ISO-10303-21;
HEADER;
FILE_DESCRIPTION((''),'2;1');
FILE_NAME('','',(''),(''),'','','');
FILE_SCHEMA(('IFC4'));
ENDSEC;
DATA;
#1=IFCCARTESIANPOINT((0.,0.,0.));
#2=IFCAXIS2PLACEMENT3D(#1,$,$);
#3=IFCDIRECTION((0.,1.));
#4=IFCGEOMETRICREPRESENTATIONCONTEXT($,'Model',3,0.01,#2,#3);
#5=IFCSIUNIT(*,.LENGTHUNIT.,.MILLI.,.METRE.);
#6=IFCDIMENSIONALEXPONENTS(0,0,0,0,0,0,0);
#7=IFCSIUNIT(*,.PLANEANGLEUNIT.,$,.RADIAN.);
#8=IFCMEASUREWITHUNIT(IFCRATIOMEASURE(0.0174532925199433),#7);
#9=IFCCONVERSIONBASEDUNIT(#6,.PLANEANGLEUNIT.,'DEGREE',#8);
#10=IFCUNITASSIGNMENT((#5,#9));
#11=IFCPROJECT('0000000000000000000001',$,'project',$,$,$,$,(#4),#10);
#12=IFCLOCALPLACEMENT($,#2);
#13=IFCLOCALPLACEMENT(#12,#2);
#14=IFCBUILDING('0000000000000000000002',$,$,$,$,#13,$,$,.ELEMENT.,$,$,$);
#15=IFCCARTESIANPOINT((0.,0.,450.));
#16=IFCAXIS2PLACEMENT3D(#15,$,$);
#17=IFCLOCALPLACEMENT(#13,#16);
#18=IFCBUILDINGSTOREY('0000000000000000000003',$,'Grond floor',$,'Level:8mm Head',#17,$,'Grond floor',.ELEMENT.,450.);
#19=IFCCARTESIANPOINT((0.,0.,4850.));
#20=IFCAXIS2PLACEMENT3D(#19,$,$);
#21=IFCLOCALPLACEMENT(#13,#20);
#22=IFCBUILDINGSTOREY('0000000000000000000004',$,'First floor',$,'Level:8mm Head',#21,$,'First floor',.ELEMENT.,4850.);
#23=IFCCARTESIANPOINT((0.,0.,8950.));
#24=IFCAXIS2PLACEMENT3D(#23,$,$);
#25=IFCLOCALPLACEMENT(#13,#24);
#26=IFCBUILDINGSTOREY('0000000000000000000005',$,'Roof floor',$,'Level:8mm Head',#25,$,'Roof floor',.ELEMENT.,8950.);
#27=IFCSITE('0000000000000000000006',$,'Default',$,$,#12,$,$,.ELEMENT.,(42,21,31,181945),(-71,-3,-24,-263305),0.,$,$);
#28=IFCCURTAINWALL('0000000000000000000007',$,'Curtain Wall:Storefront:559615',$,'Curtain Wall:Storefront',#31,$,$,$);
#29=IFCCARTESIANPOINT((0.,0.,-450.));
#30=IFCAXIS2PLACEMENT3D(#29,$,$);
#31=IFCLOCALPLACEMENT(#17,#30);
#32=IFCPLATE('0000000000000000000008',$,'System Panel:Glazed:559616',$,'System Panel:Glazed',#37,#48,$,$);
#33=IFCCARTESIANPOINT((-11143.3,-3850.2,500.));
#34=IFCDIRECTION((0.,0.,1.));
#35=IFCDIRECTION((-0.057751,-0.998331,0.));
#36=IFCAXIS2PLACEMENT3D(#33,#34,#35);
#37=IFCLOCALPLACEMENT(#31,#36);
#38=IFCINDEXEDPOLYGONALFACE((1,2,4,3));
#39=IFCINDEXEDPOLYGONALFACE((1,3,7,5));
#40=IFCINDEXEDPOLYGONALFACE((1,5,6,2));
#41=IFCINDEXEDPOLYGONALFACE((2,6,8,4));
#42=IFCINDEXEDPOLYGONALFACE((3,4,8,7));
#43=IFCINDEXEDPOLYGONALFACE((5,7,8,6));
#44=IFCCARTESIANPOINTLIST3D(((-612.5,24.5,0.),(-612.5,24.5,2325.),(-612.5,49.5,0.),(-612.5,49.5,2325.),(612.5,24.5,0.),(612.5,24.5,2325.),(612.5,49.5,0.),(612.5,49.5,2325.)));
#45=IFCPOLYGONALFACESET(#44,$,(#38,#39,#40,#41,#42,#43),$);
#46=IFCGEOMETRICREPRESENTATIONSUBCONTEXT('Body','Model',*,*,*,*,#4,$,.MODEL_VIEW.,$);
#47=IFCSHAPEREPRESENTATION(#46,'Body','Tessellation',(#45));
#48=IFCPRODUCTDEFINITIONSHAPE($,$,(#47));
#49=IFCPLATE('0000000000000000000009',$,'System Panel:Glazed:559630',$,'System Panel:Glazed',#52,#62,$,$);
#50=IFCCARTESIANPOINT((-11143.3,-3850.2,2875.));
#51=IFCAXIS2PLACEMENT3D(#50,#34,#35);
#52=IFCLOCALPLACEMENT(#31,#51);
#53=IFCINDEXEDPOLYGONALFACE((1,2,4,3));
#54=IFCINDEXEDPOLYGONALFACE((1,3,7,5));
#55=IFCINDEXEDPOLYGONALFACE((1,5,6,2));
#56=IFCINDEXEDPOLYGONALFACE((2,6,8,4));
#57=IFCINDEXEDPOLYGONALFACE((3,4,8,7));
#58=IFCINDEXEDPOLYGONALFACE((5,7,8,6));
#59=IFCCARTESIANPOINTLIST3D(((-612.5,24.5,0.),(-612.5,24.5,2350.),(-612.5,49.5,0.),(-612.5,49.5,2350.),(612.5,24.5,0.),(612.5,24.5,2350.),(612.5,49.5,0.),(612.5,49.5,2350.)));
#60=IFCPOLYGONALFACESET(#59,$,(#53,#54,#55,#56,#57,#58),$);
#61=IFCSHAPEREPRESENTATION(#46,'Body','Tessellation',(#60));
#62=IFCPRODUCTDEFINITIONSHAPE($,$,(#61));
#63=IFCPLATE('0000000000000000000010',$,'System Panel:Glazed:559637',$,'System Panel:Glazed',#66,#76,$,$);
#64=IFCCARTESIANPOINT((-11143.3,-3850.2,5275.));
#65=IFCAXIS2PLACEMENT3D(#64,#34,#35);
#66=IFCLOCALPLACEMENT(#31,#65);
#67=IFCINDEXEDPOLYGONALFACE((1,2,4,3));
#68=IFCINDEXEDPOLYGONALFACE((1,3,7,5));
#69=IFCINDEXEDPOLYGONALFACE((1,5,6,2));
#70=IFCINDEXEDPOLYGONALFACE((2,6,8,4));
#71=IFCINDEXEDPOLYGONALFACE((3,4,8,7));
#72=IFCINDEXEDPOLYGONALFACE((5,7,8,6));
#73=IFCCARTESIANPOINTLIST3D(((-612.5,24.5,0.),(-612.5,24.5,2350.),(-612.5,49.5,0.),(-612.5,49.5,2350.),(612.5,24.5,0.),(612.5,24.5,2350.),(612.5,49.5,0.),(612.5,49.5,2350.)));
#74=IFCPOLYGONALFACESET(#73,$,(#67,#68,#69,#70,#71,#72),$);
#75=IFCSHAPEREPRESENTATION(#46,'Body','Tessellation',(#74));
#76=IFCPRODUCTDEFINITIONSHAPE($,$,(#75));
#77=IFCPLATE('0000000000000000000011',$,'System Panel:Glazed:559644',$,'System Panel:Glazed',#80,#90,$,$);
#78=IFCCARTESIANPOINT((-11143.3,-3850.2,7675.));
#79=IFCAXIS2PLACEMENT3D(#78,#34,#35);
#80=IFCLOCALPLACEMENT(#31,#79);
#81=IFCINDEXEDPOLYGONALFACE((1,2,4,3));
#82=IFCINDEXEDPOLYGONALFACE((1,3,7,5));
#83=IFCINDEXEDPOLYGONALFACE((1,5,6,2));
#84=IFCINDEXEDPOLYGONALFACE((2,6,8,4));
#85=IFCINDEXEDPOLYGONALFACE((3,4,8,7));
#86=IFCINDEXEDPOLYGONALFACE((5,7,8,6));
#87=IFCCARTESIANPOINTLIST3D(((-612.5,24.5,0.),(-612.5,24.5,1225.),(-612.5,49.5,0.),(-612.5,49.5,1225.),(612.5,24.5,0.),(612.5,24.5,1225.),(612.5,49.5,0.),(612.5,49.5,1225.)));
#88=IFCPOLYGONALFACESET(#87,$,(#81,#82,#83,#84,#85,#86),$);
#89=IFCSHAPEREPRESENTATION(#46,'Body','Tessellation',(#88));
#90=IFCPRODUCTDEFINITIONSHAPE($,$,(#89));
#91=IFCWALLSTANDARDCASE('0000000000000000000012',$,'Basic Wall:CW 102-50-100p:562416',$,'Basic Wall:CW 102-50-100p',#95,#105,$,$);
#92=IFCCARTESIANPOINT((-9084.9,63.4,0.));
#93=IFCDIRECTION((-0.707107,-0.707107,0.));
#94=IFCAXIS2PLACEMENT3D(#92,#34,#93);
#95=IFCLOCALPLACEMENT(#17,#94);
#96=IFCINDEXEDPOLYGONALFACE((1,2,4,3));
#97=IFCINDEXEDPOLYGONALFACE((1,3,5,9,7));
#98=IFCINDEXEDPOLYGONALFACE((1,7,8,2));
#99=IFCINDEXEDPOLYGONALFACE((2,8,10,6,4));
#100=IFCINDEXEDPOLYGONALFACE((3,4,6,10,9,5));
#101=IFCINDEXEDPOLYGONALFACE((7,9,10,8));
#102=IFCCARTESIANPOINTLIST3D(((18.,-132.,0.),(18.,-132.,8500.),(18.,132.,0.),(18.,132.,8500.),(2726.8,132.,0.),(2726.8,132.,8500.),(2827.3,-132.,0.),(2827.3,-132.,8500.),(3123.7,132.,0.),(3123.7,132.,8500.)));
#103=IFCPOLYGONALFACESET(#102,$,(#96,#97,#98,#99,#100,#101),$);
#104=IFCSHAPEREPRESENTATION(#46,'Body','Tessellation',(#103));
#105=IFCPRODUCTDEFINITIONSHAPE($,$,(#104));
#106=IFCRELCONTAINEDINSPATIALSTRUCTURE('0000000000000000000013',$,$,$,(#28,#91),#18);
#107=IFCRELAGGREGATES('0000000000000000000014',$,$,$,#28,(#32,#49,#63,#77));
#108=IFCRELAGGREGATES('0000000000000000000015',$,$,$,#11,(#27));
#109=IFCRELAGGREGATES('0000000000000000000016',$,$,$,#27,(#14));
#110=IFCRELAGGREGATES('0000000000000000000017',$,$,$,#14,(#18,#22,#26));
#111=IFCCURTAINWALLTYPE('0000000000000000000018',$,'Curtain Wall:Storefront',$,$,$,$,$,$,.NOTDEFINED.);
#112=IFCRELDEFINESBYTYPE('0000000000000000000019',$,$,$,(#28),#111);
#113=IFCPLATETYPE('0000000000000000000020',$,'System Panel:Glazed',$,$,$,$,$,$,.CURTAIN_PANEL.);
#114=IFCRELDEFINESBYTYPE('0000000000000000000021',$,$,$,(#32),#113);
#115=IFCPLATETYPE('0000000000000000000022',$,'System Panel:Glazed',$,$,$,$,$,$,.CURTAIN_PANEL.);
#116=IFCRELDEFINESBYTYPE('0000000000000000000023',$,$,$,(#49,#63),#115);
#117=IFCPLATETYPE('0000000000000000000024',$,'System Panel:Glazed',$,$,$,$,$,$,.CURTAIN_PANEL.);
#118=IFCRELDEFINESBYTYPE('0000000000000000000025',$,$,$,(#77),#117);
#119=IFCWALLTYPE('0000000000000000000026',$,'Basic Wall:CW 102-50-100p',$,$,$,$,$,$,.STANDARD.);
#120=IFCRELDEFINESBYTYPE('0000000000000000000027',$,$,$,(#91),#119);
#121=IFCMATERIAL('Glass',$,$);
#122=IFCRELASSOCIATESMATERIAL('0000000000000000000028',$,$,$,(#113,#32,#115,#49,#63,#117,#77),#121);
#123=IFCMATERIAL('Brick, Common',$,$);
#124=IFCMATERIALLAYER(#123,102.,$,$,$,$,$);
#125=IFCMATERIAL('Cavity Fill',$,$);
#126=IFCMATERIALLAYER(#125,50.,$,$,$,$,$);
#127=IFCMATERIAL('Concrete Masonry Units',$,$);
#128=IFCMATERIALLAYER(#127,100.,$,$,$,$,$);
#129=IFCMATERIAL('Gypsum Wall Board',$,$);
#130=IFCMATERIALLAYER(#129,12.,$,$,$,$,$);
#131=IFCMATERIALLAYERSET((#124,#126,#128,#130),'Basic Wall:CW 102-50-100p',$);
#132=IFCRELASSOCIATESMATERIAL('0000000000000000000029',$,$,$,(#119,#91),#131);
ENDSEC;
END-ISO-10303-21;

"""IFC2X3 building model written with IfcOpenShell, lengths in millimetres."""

from ifc_helpers import new_model, entity, si_unit, converted_unit, direction, frame, frame_2d, origin, place, context, subcontext, project, spatial, polyline, rectangle, outline, extrude, source, transform, mapped, material, layer, layer_set, layer_usage, type_object, type_shapes, element, aggregate, save


model = new_model("IFC2X3")

# Units and contexts
model_context = context("Model", 3, precision=0.01, world=origin(), true_north=direction((0.0, 1.0)))
body_context = subcontext(model_context, "Body", "Model", "MODEL_VIEW")
ifc_project = project(units=[si_unit("LENGTHUNIT", "METRE", prefix="MILLI"), converted_unit("PLANEANGLEUNIT", "DEGREE", entity("IfcRatioMeasure", 0.0174532925199433), si_unit("PLANEANGLEUNIT", "RADIAN"), dimensions=[0, 0, 0, 0, 0, 0, 0])], contexts=[model_context])

# Site, building, storey
site_placement = place(None, origin())
site = spatial("IfcSite", under=ifc_project, at=site_placement, Name="Default", CompositionType="ELEMENT", RefLatitude=(42, 21, 31, 181945), RefLongitude=(-71, -3, -24, -263305), RefElevation=0.0)
building_placement = place(site_placement, origin())
building = spatial("IfcBuilding", under=site, at=building_placement, CompositionType="ELEMENT")
storey_1_placement = place(building_placement, frame((0.0, 0.0, 450.0)))
storey_1 = spatial("IfcBuildingStorey", under=building, at=storey_1_placement, Name="Grond floor", ObjectType="Level:8mm Head", LongName="Grond floor", CompositionType="ELEMENT", Elevation=450.0)

# Shared definitions
curtain_wall_type = type_object("IfcCurtainWallType", Name="Curtain Wall:Storefront", PredefinedType="NOTDEFINED")

# Curtain wall, plates
curtain_wall_1_placement = place(storey_1_placement, frame((0.0, 0.0, -450.0)))
curtain_wall_1 = element("IfcCurtainWall", 1, at=curtain_wall_1_placement, inside=storey_1, type_object=curtain_wall_type, Name="Curtain Wall:Storefront:559615", ObjectType="Curtain Wall:Storefront")
ifc_material_1 = material(Name="Glass")
plate_type_1 = type_object("IfcPlateType", Name="System Panel:Glazed", PredefinedType="CURTAIN_PANEL", material=ifc_material_1)
shared_shape_1 = source(origin(), body_context, "Body", "SweptSolid", [
    extrude(rectangle(XDim=25.0, YDim=1225.0, at=frame_2d((0.0, 0.0), x_axis=(1.0, 0.0))), frame((0.0, 37.0, 0.0), z_axis=(0.0, 0.0, 1.0), x_axis=(0.0, 1.0, 0.0)), (0.0, 0.0, 1.0), 2325.0),
])
type_shapes(plate_type_1, [shared_shape_1])
plate_1_placement = place(curtain_wall_1_placement, frame((-11143.3, -3850.2, 500.0), z_axis=(0.0, 0.0, 1.0), x_axis=(-0.057751, -0.998331, 0.0)))
plate_1 = element("IfcPlate", 2, at=plate_1_placement, type_object=plate_type_1, material=ifc_material_1, Name="System Panel:Glazed:559616", ObjectType="System Panel:Glazed", context=body_context, shape_type="MappedRepresentation", body=[
    mapped(shared_shape_1, transform((0.0, 0.0, 0.0), scale=1.0)),
])
plate_type_2 = type_object("IfcPlateType", Name="System Panel:Glazed", PredefinedType="CURTAIN_PANEL", material=ifc_material_1)
shared_shape_2 = source(origin(), body_context, "Body", "SweptSolid", [
    extrude(rectangle(XDim=25.0, YDim=1225.0, at=frame_2d((0.0, 0.0), x_axis=(1.0, 0.0))), frame((0.0, 37.0, 0.0), z_axis=(0.0, 0.0, 1.0), x_axis=(0.0, 1.0, 0.0)), (0.0, 0.0, 1.0), 2350.0),
])
type_shapes(plate_type_2, [shared_shape_2])
plate_2_placement = place(curtain_wall_1_placement, frame((-11143.3, -3850.2, 2875.0), z_axis=(0.0, 0.0, 1.0), x_axis=(-0.057751, -0.998331, 0.0)))
plate_2 = element("IfcPlate", 3, at=plate_2_placement, type_object=plate_type_2, material=ifc_material_1, Name="System Panel:Glazed:559630", ObjectType="System Panel:Glazed", context=body_context, shape_type="MappedRepresentation", body=[
    mapped(shared_shape_2, transform((0.0, 0.0, 0.0), scale=1.0)),
])
plate_3_placement = place(curtain_wall_1_placement, frame((-11143.3, -3850.2, 5275.0), z_axis=(0.0, 0.0, 1.0), x_axis=(-0.057751, -0.998331, 0.0)))
plate_3 = element("IfcPlate", 4, at=plate_3_placement, type_object=plate_type_2, material=ifc_material_1, Name="System Panel:Glazed:559637", ObjectType="System Panel:Glazed", context=body_context, shape_type="MappedRepresentation", body=[
    mapped(shared_shape_2, transform((0.0, 0.0, 0.0), scale=1.0)),
])
plate_type_3 = type_object("IfcPlateType", Name="System Panel:Glazed", PredefinedType="CURTAIN_PANEL", material=ifc_material_1)
shared_shape_3 = source(origin(), body_context, "Body", "SweptSolid", [
    extrude(rectangle(XDim=25.0, YDim=1225.0, at=frame_2d((0.0, 0.0), x_axis=(1.0, 0.0))), frame((0.0, 37.0, 0.0), z_axis=(0.0, 0.0, 1.0), x_axis=(0.0, 1.0, 0.0)), (0.0, 0.0, 1.0), 1225.0),
])
type_shapes(plate_type_3, [shared_shape_3])
plate_4_placement = place(curtain_wall_1_placement, frame((-11143.3, -3850.2, 7675.0), z_axis=(0.0, 0.0, 1.0), x_axis=(-0.057751, -0.998331, 0.0)))
plate_4 = element("IfcPlate", 5, at=plate_4_placement, type_object=plate_type_3, material=ifc_material_1, Name="System Panel:Glazed:559644", ObjectType="System Panel:Glazed", context=body_context, shape_type="MappedRepresentation", body=[
    mapped(shared_shape_3, transform((0.0, 0.0, 0.0), scale=1.0)),
])
aggregate(curtain_wall_1, [plate_1, plate_2, plate_3, plate_4])

# Wall
ifc_material_2 = material(Name="Brick, Common")
ifc_layer_1 = layer(ifc_material_2, 102.0)
ifc_material_3 = material(Name="Cavity Fill")
ifc_layer_2 = layer(ifc_material_3, 50.0)
ifc_material_4 = material(Name="Concrete Masonry Units")
ifc_layer_3 = layer(ifc_material_4, 100.0)
ifc_material_5 = material(Name="Gypsum Wall Board")
ifc_layer_4 = layer(ifc_material_5, 12.0)
ifc_layer_set_1 = layer_set([ifc_layer_1, ifc_layer_2, ifc_layer_3, ifc_layer_4], Name="Basic Wall:CW 102-50-100p")
wall_type_1 = type_object("IfcWallType", Name="Basic Wall:CW 102-50-100p", PredefinedType="STANDARD", material=ifc_layer_set_1)
ifc_layer_usage_1 = layer_usage(ifc_layer_set_1, "AXIS2", "POSITIVE", -132.0)
wall_1_placement = place(storey_1_placement, frame((-9084.9, 63.4, 0.0), z_axis=(0.0, 0.0, 1.0), x_axis=(-0.707107, -0.707107, 0.0)))
element("IfcWallStandardCase", 6, at=wall_1_placement, inside=storey_1, type_object=wall_type_1, material=ifc_layer_usage_1, Name="Basic Wall:CW 102-50-100p:562416", ObjectType="Basic Wall:CW 102-50-100p", context=body_context, shape_type="SweptSolid", body=[
    extrude(outline(polyline([(2827.3, -132.0), (3123.7, 132.0), (2726.8, 132.0), (18.0, 132.0), (18.0, -132.0), (2827.3, -132.0)])), origin(), (0.0, 0.0, 1.0), 8500.0),
])

# Shared definitions
storey_2_placement = place(building_placement, frame((0.0, 0.0, 4850.0)))
storey_2 = spatial("IfcBuildingStorey", under=building, at=storey_2_placement, Name="First floor", ObjectType="Level:8mm Head", LongName="First floor", CompositionType="ELEMENT", Elevation=4850.0)

# Shared definitions
storey_3_placement = place(building_placement, frame((0.0, 0.0, 8950.0)))
storey_3 = spatial("IfcBuildingStorey", under=building, at=storey_3_placement, Name="Roof floor", ObjectType="Level:8mm Head", LongName="Roof floor", CompositionType="ELEMENT", Elevation=8950.0)

save(model, "model.ifc")
